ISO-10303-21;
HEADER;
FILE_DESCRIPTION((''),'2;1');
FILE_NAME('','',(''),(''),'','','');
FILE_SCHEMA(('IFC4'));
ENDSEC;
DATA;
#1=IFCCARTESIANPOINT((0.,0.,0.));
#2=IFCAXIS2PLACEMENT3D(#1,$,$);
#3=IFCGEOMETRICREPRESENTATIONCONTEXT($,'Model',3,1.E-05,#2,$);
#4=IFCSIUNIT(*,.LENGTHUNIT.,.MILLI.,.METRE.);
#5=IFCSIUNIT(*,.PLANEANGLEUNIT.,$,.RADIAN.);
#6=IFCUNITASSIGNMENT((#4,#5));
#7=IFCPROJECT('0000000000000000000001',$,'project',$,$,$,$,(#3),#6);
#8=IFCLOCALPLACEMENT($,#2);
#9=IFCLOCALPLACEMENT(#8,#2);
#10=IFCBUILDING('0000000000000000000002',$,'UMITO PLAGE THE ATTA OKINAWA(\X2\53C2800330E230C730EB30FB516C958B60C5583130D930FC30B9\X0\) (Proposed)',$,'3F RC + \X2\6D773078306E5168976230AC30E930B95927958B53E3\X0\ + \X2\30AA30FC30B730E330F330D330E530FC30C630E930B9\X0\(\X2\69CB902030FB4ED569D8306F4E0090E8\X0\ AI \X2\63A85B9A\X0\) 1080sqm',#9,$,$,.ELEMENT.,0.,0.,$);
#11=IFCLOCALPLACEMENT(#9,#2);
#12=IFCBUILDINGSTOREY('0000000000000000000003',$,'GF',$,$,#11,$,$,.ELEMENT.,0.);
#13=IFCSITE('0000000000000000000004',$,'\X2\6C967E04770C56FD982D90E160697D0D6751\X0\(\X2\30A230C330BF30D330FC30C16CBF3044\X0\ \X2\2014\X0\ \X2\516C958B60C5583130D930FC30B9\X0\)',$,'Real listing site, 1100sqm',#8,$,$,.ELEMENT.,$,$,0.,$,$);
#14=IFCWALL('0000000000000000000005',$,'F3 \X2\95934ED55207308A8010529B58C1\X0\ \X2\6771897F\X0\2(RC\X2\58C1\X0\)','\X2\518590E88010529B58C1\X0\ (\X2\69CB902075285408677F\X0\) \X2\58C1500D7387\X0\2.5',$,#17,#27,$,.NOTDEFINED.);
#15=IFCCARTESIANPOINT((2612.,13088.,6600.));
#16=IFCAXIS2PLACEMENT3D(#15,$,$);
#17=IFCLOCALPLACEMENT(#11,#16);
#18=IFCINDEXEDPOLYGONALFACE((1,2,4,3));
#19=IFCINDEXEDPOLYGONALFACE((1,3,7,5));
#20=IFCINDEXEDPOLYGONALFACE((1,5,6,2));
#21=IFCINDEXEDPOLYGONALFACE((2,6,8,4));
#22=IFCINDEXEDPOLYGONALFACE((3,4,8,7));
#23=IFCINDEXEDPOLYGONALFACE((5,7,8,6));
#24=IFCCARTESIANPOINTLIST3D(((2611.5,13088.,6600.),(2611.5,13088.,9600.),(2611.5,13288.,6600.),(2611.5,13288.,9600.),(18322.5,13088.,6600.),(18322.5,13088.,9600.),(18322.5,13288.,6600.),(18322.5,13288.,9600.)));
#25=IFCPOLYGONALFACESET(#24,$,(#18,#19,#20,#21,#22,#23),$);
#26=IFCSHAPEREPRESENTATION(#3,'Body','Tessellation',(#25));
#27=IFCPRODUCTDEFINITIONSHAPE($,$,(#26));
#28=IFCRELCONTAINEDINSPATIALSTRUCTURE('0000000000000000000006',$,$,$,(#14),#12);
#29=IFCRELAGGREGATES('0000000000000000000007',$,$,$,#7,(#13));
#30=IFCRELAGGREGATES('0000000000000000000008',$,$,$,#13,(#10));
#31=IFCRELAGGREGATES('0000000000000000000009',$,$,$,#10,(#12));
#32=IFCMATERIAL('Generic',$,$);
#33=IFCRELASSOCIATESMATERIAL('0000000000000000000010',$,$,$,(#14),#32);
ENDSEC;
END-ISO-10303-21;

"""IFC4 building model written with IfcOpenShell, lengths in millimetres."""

from ifc_helpers import new_model, si_unit, frame, frame_2d, origin, place, context, project, spatial, rectangle, extrude, material, element, save


model = new_model("IFC4")

# Units and contexts
model_context = context("Model", 3, precision=1e-05, world=origin())
ifc_project = project(units=[si_unit("LENGTHUNIT", "METRE", prefix="MILLI"), si_unit("PLANEANGLEUNIT", "RADIAN")], contexts=[model_context])

# Site, building, storey
site_placement = place(None, origin())
site = spatial("IfcSite", under=ifc_project, at=site_placement, Name="沖縄県国頭郡恩納村(アッタビーチ沿い — 公開情報ベース)", ObjectType="Real listing site, 1100sqm", CompositionType="ELEMENT", RefElevation=0.0)
building_placement = place(site_placement, origin())
building = spatial("IfcBuilding", under=site, at=building_placement, Name="UMITO PLAGE THE ATTA OKINAWA(参考モデル・公開情報ベース) (Proposed)", ObjectType="3F RC + 海への全面ガラス大開口 + オーシャンビューテラス(構造・仕様は一部 AI 推定) 1080sqm", CompositionType="ELEMENT", ElevationOfRefHeight=0.0, ElevationOfTerrain=0.0)
storey_placement = place(building_placement, origin())
storey = spatial("IfcBuildingStorey", under=building, at=storey_placement, Name="GF", CompositionType="ELEMENT", Elevation=0.0)

# Shared definitions
ifc_material = material(Name="Generic")

# Wall
wall_1_placement = place(storey_placement, frame((2612.0, 13088.0, 6600.0)))
element("IfcWall", 1, at=wall_1_placement, inside=storey, material=ifc_material, Name="F3 間仕切り耐力壁 東西2(RC壁)", Description="内部耐力壁 (構造用合板) 壁倍率2.5", PredefinedType="NOTDEFINED", context=model_context, shape_type="SweptSolid", body=[
    extrude(rectangle(XDim=15711.0, YDim=200.0, at=frame_2d((7855.0, 100.0))), frame((2612.0, 13088.0, 6600.0)), (0.0, 0.0, 1.0), 3000.0),
])

save(model, "model.ifc")
